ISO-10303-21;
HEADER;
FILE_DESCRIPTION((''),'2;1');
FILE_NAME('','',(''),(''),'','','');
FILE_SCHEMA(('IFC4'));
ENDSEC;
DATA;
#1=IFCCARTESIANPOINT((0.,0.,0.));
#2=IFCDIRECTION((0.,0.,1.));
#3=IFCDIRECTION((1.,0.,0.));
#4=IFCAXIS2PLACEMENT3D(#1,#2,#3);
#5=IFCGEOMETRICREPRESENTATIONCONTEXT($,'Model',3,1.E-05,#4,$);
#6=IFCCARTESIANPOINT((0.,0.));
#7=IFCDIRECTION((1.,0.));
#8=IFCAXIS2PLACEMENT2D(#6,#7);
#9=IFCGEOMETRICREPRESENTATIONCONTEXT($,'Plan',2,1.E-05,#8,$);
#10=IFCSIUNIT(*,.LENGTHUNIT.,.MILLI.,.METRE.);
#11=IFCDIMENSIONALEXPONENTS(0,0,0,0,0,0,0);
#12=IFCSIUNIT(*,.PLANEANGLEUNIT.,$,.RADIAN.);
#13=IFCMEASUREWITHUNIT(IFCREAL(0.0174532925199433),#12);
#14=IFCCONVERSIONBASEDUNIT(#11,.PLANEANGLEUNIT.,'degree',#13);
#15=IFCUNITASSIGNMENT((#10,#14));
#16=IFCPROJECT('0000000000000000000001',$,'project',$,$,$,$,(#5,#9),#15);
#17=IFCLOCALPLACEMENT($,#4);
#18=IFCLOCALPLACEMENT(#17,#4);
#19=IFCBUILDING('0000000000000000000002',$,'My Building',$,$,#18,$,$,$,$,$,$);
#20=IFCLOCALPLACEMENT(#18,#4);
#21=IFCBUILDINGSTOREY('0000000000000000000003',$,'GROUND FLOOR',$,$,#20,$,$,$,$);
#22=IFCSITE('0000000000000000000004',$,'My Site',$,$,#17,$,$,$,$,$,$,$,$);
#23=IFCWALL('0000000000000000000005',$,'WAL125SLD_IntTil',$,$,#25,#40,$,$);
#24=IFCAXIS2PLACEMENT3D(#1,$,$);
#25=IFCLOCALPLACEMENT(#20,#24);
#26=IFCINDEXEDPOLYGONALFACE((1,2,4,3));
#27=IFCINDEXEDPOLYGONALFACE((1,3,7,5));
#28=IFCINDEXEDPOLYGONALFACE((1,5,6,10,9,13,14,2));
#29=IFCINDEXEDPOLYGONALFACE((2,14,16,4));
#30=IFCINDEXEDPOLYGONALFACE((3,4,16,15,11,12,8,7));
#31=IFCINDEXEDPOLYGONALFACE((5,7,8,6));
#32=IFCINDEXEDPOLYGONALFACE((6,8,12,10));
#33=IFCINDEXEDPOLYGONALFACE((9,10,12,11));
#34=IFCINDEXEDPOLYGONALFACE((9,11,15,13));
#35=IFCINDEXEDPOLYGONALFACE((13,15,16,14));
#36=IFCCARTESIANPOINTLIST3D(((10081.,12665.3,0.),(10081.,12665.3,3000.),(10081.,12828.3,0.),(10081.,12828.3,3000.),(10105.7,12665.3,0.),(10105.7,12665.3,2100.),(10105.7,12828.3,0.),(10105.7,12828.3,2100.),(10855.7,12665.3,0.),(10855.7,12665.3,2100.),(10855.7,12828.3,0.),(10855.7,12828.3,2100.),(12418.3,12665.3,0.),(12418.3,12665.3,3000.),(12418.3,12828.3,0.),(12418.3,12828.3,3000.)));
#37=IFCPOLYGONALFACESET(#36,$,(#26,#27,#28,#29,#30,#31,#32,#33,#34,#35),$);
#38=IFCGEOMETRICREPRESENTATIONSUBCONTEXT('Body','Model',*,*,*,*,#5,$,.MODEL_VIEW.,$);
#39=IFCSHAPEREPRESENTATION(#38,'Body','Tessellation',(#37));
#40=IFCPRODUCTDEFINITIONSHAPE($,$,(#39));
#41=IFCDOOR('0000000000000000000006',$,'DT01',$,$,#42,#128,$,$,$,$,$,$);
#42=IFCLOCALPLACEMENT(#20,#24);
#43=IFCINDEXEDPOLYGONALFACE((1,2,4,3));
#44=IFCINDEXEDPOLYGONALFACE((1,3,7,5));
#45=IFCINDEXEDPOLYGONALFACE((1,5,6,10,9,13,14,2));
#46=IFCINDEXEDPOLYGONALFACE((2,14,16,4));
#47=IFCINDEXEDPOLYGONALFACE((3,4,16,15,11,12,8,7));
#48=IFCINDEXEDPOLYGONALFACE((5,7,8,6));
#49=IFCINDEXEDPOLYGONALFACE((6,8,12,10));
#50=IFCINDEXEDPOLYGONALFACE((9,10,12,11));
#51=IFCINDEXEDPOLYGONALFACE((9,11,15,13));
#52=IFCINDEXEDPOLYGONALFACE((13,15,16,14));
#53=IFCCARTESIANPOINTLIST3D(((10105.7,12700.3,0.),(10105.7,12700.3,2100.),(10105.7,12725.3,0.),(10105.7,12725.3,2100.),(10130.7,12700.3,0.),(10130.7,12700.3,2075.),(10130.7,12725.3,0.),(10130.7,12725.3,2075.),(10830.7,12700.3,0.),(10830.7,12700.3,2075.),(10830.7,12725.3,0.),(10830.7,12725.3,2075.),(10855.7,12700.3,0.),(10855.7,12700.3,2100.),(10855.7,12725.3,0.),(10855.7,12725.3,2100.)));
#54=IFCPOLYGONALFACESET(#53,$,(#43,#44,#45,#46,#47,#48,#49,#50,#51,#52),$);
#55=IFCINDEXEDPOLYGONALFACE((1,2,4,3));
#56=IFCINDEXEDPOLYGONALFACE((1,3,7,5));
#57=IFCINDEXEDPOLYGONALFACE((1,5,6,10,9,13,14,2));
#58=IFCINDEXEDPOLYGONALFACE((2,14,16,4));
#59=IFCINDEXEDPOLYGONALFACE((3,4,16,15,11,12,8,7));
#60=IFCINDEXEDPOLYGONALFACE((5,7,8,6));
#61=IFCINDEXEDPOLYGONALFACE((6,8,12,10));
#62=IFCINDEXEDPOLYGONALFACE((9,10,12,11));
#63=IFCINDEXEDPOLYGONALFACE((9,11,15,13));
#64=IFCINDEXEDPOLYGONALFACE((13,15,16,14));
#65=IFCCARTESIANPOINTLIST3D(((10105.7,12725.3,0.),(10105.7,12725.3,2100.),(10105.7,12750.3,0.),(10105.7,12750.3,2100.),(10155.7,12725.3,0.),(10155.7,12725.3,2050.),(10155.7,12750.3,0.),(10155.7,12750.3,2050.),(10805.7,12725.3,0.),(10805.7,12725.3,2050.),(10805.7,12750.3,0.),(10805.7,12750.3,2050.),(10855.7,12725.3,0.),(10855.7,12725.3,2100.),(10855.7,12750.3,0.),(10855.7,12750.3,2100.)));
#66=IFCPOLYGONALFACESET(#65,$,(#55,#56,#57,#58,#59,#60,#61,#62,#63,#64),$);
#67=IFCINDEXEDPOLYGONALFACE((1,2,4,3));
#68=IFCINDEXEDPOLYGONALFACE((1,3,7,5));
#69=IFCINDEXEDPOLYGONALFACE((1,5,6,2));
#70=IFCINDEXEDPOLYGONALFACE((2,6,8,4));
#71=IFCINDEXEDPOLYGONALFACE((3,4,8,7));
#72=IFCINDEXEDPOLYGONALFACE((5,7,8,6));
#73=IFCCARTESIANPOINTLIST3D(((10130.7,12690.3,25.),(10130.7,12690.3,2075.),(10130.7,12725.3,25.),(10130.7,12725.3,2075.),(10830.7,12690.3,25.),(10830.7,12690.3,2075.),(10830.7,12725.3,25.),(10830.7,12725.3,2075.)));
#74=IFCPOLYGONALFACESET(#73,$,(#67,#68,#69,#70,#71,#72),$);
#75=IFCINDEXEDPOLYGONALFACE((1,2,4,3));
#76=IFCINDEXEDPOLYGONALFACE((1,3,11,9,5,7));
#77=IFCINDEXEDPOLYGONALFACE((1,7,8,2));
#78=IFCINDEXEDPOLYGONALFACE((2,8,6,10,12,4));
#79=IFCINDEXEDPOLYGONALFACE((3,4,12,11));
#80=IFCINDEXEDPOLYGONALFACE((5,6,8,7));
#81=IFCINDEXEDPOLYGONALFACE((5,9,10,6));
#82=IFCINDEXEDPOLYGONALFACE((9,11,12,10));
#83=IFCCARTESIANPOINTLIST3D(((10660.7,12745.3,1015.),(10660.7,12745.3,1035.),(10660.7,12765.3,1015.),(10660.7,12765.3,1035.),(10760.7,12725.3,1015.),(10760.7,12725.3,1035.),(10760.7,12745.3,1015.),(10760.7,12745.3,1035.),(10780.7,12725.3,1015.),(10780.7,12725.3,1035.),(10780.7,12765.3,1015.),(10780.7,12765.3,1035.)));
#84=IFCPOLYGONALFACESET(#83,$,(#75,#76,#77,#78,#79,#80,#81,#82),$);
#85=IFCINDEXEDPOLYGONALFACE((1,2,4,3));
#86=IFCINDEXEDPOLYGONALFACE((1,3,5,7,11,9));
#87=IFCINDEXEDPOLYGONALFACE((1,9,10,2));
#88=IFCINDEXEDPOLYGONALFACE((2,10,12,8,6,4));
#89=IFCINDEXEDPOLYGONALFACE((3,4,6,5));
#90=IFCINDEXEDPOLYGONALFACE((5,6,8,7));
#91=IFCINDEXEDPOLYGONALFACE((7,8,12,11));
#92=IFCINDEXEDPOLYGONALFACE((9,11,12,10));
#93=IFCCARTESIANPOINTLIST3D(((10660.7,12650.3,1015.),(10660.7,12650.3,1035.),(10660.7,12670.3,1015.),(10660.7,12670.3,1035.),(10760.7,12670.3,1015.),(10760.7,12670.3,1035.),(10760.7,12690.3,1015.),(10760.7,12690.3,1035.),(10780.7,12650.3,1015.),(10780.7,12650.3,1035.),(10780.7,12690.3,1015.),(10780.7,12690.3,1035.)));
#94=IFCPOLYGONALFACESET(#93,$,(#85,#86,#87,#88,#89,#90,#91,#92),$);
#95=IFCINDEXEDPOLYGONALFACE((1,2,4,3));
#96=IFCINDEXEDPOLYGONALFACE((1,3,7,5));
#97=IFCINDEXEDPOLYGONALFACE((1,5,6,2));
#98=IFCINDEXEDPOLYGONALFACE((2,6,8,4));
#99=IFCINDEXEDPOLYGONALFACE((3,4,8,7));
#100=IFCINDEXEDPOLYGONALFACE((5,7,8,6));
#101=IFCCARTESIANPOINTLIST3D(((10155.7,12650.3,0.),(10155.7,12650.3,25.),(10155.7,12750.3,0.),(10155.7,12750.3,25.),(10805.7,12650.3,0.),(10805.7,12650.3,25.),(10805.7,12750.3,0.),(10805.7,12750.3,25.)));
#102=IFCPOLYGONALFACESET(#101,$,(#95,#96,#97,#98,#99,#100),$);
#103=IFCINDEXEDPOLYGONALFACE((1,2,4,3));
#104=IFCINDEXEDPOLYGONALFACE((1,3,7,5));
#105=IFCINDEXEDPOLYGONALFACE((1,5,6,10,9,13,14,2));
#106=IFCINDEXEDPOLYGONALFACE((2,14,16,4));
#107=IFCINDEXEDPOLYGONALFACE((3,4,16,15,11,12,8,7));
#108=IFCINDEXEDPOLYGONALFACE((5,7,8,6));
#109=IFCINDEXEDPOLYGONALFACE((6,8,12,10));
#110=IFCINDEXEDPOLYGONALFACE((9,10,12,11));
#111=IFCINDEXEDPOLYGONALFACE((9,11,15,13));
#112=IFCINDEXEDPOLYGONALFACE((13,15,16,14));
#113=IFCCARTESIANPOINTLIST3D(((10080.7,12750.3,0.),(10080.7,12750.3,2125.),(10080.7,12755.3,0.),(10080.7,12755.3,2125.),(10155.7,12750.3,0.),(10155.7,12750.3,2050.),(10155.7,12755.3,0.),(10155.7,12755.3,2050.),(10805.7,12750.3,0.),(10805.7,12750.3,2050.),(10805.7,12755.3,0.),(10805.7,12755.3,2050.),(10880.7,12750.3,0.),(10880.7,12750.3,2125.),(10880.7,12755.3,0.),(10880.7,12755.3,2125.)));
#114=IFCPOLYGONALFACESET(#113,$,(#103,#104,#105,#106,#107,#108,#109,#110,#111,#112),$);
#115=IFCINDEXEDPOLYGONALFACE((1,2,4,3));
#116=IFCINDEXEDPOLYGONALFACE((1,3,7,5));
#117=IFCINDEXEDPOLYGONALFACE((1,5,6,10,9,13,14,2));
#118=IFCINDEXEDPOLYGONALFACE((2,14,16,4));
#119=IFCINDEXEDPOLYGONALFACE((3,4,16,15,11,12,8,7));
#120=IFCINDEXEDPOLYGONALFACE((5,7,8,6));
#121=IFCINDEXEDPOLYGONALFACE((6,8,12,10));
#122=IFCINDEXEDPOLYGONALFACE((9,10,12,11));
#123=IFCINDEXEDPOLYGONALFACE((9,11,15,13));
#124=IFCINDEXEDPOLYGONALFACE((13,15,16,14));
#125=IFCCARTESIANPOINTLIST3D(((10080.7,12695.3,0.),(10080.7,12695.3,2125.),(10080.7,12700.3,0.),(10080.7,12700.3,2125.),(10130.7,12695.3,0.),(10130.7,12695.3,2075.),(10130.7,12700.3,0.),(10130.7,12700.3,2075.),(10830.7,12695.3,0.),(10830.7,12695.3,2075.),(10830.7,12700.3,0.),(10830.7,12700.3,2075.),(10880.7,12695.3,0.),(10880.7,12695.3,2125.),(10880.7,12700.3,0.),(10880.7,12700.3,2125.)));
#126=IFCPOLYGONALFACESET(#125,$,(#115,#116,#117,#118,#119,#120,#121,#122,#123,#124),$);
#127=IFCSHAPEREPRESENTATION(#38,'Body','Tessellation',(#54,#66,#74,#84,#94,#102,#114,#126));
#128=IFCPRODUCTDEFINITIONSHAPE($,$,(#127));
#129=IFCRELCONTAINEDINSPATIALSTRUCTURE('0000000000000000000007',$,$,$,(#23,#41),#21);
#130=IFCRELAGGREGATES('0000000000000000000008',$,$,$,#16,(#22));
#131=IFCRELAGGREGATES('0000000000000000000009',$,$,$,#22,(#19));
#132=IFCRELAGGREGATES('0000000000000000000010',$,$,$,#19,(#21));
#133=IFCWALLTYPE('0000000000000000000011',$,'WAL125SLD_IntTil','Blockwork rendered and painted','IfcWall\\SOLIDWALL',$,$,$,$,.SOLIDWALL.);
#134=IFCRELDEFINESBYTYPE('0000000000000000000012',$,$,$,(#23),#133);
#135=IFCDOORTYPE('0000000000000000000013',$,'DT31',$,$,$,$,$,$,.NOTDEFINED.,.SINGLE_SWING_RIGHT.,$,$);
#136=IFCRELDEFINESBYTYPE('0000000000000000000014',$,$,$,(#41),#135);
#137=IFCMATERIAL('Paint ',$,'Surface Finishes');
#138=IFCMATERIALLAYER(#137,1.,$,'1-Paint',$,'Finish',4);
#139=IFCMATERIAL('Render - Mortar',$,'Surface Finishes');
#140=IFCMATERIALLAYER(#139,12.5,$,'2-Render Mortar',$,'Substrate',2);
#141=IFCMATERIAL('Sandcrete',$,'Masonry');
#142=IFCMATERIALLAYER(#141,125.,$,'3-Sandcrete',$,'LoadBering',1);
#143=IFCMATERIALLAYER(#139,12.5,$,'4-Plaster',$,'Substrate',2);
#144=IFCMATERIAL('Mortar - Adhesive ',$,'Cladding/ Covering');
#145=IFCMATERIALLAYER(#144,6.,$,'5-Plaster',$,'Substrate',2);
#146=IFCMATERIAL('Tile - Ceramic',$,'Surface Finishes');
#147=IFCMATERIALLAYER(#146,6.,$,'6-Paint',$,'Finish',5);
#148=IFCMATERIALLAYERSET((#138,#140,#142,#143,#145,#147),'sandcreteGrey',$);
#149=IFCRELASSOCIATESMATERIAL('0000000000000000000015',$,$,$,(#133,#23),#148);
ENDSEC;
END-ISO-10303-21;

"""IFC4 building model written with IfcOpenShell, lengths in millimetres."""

from ifc_helpers import new_model, entity, si_unit, converted_unit, frame, origin_with_axes, origin_2d_with_axis, place, context, subcontext, project, spatial, line, indexed_curve, outline, extrude, shape, source, transform, mapped, material, layer, layer_set, layer_usage, type_object, type_shapes, element, fill, save


model = new_model("IFC4")

# Units and contexts
model_context = context("Model", 3, precision=1e-05, world=origin_with_axes())
plan_context = context("Plan", 2, precision=1e-05, world=origin_2d_with_axis())
body_context_1 = subcontext(model_context, "Body", "Model", "MODEL_VIEW")
body_context_2 = subcontext(plan_context, "Body", "Plan", "PLAN_VIEW")
ifc_project = project(units=[si_unit("LENGTHUNIT", "METRE", prefix="MILLI"), converted_unit("PLANEANGLEUNIT", "degree", entity("IfcReal", 0.0174532925199433), si_unit("PLANEANGLEUNIT", "RADIAN"), dimensions=[0, 0, 0, 0, 0, 0, 0])], contexts=[model_context, plan_context])

# Site, building, storey
site_placement = place(None, origin_with_axes())
site = spatial("IfcSite", under=ifc_project, at=site_placement, Name="My Site")
building_placement = place(site_placement, origin_with_axes())
building = spatial("IfcBuilding", under=site, at=building_placement, Name="My Building")
storey_placement = place(building_placement, origin_with_axes())
storey = spatial("IfcBuildingStorey", under=building, at=storey_placement, Name="GROUND FLOOR")

# Shared definitions
ifc_material_1 = material(Name="Paint ", Category="Surface Finishes")
ifc_material_2 = material(Name="Render - Mortar", Category="Surface Finishes")
ifc_material_3 = material(Name="Sandcrete", Category="Masonry")

# Shared definitions
ifc_layer_1 = layer(ifc_material_1, 1.0, Name="1-Paint", Category="Finish", Priority=4)
ifc_layer_2 = layer(ifc_material_2, 12.5, Name="2-Render Mortar", Category="Substrate", Priority=2)
ifc_layer_3 = layer(ifc_material_3, 125.0, Name="3-Sandcrete", Category="LoadBering", Priority=1)
ifc_layer_4 = layer(ifc_material_2, 12.5, Name="4-Plaster", Category="Substrate", Priority=2)
ifc_material_4 = material(Name="Mortar - Adhesive ", Category="Cladding/ Covering")
ifc_layer_5 = layer(ifc_material_4, 6.0, Name="5-Plaster", Category="Substrate", Priority=2)
ifc_material_5 = material(Name="Tile - Ceramic", Category="Surface Finishes")
ifc_layer_6 = layer(ifc_material_5, 6.0, Name="6-Paint", Category="Finish", Priority=5)
ifc_layer_set_1 = layer_set([ifc_layer_1, ifc_layer_2, ifc_layer_3, ifc_layer_4, ifc_layer_5, ifc_layer_6], Name="sandcreteGrey")
wall_type_1 = type_object("IfcWallType", Name="WAL125SLD_IntTil", Description="Blockwork rendered and painted", ApplicableOccurrence="IfcWall\\SOLIDWALL", PredefinedType="SOLIDWALL", material=ifc_layer_set_1)

# Wall, opening, door
ifc_layer_usage_1 = layer_usage(ifc_layer_set_1, "AXIS2", "POSITIVE", 0.0)
wall_1_placement = place(storey_placement, frame((10081.0, 12665.3, 0.0), z_axis=(0.0, 0.0, 1.0), x_axis=(1.0, -0.000001, 0.0)))
wall_1 = element("IfcWall", 1, at=wall_1_placement, inside=storey, type_object=wall_type_1, material=ifc_layer_usage_1, Name="WAL125SLD_IntTil", context=body_context_1, shape_type="SweptSolid", body=[
    extrude(outline(indexed_curve([(0.0, 0.0), (0.0, 163.0), (2337.3, 163.0), (2337.3, 0.0), (0.0, 0.0)], self_intersect=False)), origin_with_axes(), (0.0, 0.0, 1.0), 3000.0),
])
shared_shape_1 = source(origin_with_axes(), body_context_1, "Body", "SweptSolid", [
    extrude(outline(indexed_curve([(0.0, 0.0), (750.0, 0.0), (750.0, 2100.0), (0.0, 2100.0)], segments=[line(1, 2, 3, 4, 1)])), frame((0.0, -600.0, 0.0), z_axis=(0.0, -1.0, 0.0), x_axis=(1.0, 0.0, 0.0)), (0.0, 0.0, -1.0), 1200.0),
])
opening_1_placement = place(wall_1_placement, frame((774.7, 85.0, 0.0), z_axis=(0.0, 0.0, 1.0), x_axis=(-1.0, 0.0, 0.0)))
opening_1 = element("IfcOpeningElement", 2, at=opening_1_placement, cuts=wall_1, PredefinedType="OPENING", context=body_context_1, shape_type="MappedRepresentation", body=[
    mapped(shared_shape_1, transform((0.0, 0.0, 0.0), x_axis=(1.0, 0.0, 0.0), y_axis=(0.0, 1.0, 0.0), z_axis=(0.0, 0.0, 1.0), scale=1.0)),
])
door_type_1 = type_object("IfcDoorType", Name="DT31", OperationType="SINGLE_SWING_RIGHT", PredefinedType="NOTDEFINED")
shared_shape_2 = source(origin_with_axes(), body_context_1, "Body", "SweptSolid", [
    extrude(outline(indexed_curve([(0.0, 0.0), (0.0, 2100.0), (750.0, 2100.0), (750.0, 0.0), (725.0, 0.0), (725.0, 2075.0), (25.0, 2075.0), (25.0, 0.0)], segments=[line(1, 2, 3, 4, 5, 6, 7, 8, 1)])), frame((0.0, 25.0, 0.0), z_axis=(0.0, -1.0, 0.0), x_axis=(1.0, 0.0, 0.0)), (0.0, 0.0, -1.0), 25.0),
    extrude(outline(indexed_curve([(0.0, 0.0), (0.0, 2100.0), (750.0, 2100.0), (750.0, 0.0), (700.0, 0.0), (700.0, 2050.0), (50.0, 2050.0), (50.0, 0.0)], segments=[line(1, 2, 3, 4, 5, 6, 7, 8, 1)])), frame((0.0, 0.0, 0.0), z_axis=(0.0, -1.0, 0.0), x_axis=(1.0, 0.0, 0.0)), (0.0, 0.0, -1.0), 25.0),
    extrude(outline(indexed_curve([(0.0, 0.0), (700.0, 0.0), (700.0, 35.0), (0.0, 35.0)], segments=[line(1, 2, 3, 4, 1)])), frame((25.0, 25.0, 25.0), z_axis=(0.0, 0.0, 1.0), x_axis=(1.0, 0.0, 0.0)), (0.0, 0.0, 1.0), 2050.0),
    extrude(outline(indexed_curve([(0.0, 0.0), (0.0, -40.0), (120.0, -40.0), (120.0, -20.0), (20.0, -20.0), (20.0, 0.0)], segments=[line(1, 2, 3, 4, 5, 6, 1)])), frame((75.0, 25.0, 1015.0), z_axis=(0.0, 0.0, 1.0), x_axis=(1.0, 0.0, 0.0)), (0.0, 0.0, 1.0), 20.0),
    extrude(outline(indexed_curve([(0.0, 0.0), (0.0, 40.0), (120.0, 40.0), (120.0, 20.0), (20.0, 20.0), (20.0, 0.0)], segments=[line(1, 2, 3, 4, 5, 6, 1)])), frame((75.0, 60.0, 1015.0), z_axis=(0.0, 0.0, 1.0), x_axis=(1.0, 0.0, 0.0)), (0.0, 0.0, 1.0), 20.0),
    extrude(outline(indexed_curve([(0.0, 0.0), (650.0, 0.0), (650.0, 100.0), (0.0, 100.0)], segments=[line(1, 2, 3, 4, 1)])), frame((50.0, 0.0, 0.0), z_axis=(0.0, 0.0, 1.0), x_axis=(1.0, 0.0, 0.0)), (0.0, 0.0, 1.0), 25.0),
    extrude(outline(indexed_curve([(0.0, 0.0), (0.0, 2125.0), (800.0, 2125.0), (800.0, 0.0), (725.0, 0.0), (725.0, 2050.0), (75.0, 2050.0), (75.0, 0.0)], segments=[line(1, 2, 3, 4, 5, 6, 7, 8, 1)])), frame((-25.0, -5.0, 0.0), z_axis=(0.0, -1.0, 0.0), x_axis=(1.0, 0.0, 0.0)), (0.0, 0.0, -1.0), 5.0),
    extrude(outline(indexed_curve([(0.0, 0.0), (0.0, 2125.0), (800.0, 2125.0), (800.0, 0.0), (750.0, 0.0), (750.0, 2075.0), (50.0, 2075.0), (50.0, 0.0)], segments=[line(1, 2, 3, 4, 5, 6, 7, 8, 1)])), frame((-25.0, 50.0, 0.0), z_axis=(0.0, -1.0, 0.0), x_axis=(1.0, 0.0, 0.0)), (0.0, 0.0, -1.0), 5.0),
])
shared_shape_3 = source(origin_with_axes(), body_context_2, "Body", "Curve2D", [
    entity("IfcIndexedPolyCurve", entity("IfcCartesianPointList2D", [[0.0, 0.0], [0.0, 50.0], [25.0, 50.0], [25.0, 25.0], [50.0, 25.0], [50.0, 0.0]]), [entity("IfcLineIndex", [1, 2, 3, 4, 5, 6, 1])]),
    entity("IfcIndexedPolyCurve", entity("IfcCartesianPointList2D", [[750.0, 0.0], [750.0, 50.0], [725.0, 50.0], [725.0, 25.0], [700.0, 25.0], [700.0, 0.0]]), [entity("IfcLineIndex", [1, 2, 3, 4, 5, 6, 1])]),
    entity("IfcTrimmedCurve", entity("IfcEllipse", entity("IfcAxis2Placement2D", entity("IfcCartesianPoint", [690.0, 50.0]), entity("IfcDirection", [1.0, 0.0])), 665.0, 700.0), [entity("IfcCartesianPoint", [690.0, 750.0])], [entity("IfcCartesianPoint", [25.0, 50.0])], True, "CARTESIAN"),
    entity("IfcIndexedPolyCurve", entity("IfcCartesianPointList2D", [[725.0, 50.0], [690.0, 50.0], [690.0, 750.0], [725.0, 750.0]]), [entity("IfcLineIndex", [1, 2, 3, 4, 1])]),
])
type_shapes(door_type_1, [shared_shape_2, shared_shape_3])
door_1_placement = place(opening_1_placement, origin_with_axes())
door_1 = element("IfcDoor", 3, at=door_1_placement, inside=storey, type_object=door_type_1, Name="DT01", shapes=[
    shape(body_context_1, "Body", "MappedRepresentation", [mapped(shared_shape_2, transform((0.0, 0.0, 0.0), x_axis=(1.0, 0.0, 0.0), y_axis=(0.0, 1.0, 0.0), z_axis=(0.0, 0.0, 1.0), scale=1.0))]),
    shape(body_context_2, "Body", "MappedRepresentation", [mapped(shared_shape_3, transform((0.0, 0.0, 0.0), x_axis=(1.0, 0.0, 0.0), y_axis=(0.0, 1.0, 0.0), z_axis=(0.0, 0.0, 1.0), scale=1.0))]),
])
fill(opening_1, door_1)

save(model, "model.ifc")
